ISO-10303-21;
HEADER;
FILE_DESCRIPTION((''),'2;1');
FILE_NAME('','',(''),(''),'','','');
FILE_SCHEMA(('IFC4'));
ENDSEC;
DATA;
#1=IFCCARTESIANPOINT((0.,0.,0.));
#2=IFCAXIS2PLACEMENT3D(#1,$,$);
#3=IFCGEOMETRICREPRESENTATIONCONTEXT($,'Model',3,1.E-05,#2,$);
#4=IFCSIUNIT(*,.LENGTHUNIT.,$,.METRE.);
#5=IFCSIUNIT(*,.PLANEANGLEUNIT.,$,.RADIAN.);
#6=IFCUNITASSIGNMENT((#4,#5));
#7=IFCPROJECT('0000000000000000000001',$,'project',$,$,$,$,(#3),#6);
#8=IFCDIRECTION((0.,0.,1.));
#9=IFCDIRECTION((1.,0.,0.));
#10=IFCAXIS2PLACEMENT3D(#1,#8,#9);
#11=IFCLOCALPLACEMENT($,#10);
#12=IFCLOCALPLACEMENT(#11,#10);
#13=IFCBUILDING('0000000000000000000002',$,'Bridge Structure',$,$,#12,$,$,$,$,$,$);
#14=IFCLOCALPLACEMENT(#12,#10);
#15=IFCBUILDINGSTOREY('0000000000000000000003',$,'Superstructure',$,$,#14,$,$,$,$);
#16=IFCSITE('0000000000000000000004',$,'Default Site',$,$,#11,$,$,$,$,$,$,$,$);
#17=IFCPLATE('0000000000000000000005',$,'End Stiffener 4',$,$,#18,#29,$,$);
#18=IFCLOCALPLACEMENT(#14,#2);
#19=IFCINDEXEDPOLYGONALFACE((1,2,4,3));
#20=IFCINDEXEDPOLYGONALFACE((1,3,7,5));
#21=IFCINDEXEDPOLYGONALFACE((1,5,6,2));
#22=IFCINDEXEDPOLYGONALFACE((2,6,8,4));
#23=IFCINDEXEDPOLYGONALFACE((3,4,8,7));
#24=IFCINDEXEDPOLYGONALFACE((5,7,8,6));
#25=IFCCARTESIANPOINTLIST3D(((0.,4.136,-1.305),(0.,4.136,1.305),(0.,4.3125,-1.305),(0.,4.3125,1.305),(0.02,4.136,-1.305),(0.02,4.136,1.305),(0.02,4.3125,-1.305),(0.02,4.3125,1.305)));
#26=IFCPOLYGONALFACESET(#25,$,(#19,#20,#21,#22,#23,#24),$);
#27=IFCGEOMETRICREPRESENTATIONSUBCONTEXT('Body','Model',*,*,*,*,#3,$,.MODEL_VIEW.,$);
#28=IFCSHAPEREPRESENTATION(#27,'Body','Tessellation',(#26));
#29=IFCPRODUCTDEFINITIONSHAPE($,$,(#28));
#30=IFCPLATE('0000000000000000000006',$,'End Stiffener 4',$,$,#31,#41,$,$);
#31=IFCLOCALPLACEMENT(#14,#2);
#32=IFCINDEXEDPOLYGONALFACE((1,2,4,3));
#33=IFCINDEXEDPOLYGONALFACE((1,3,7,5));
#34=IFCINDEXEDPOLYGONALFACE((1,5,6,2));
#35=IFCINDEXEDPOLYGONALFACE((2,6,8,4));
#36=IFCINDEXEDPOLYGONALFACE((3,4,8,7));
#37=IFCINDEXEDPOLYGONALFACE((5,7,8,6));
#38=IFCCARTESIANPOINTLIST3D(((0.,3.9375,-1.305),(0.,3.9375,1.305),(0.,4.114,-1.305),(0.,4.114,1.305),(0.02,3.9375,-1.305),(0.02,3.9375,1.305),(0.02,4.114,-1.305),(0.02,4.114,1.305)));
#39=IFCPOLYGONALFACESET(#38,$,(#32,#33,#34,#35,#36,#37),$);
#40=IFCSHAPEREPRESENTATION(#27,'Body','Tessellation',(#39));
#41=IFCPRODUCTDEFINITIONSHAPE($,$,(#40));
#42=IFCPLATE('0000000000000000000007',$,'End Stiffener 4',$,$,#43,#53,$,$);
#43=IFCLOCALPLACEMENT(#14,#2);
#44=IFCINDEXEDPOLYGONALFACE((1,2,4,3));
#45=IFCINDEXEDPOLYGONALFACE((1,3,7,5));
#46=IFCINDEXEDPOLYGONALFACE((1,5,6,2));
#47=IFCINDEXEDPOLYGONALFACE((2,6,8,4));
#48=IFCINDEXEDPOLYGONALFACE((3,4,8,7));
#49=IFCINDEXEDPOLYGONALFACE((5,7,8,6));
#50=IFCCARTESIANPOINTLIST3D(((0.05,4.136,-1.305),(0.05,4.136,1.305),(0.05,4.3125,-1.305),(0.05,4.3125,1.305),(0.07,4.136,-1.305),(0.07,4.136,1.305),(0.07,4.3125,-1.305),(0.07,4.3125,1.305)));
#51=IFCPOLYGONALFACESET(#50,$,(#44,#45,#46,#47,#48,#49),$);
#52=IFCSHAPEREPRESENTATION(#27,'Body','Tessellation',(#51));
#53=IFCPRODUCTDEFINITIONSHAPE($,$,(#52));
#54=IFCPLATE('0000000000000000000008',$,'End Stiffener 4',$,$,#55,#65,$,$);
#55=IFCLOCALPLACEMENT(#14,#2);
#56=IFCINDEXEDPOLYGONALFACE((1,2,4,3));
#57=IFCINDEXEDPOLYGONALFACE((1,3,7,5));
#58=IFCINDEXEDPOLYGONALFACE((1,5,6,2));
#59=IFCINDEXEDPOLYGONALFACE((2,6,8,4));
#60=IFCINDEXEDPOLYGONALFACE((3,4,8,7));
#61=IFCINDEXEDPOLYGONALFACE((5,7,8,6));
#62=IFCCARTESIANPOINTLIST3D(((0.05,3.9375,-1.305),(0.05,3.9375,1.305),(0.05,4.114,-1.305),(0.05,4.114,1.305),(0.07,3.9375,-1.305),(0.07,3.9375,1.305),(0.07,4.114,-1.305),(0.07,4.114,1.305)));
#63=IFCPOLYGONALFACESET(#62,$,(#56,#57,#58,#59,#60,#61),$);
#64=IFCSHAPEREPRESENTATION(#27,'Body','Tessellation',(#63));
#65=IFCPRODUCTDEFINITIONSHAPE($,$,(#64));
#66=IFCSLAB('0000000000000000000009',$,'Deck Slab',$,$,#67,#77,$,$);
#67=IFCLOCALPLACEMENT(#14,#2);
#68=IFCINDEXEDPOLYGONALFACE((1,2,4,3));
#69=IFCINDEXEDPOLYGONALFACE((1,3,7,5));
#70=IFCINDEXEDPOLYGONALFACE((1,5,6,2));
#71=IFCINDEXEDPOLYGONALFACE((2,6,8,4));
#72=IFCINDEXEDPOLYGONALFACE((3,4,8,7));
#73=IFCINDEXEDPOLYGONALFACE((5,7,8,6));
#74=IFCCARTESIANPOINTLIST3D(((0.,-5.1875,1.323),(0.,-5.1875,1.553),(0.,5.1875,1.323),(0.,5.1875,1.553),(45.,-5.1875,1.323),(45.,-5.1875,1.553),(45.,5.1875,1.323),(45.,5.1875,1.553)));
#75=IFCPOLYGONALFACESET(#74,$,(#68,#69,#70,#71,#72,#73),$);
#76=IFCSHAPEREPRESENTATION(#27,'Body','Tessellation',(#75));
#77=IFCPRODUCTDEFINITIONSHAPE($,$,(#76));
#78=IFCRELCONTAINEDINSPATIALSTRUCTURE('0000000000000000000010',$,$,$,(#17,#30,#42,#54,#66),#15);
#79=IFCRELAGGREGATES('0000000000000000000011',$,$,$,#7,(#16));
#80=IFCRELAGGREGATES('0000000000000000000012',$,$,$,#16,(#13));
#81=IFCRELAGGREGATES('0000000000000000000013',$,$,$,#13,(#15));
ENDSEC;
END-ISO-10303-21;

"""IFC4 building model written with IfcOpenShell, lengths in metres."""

from ifc_helpers import new_model, si_unit, frame, origin, origin_with_axes, origin_2d_with_axis, place, context, subcontext, project, spatial, polyline, rectangle, outline, extrude, element, save


model = new_model("IFC4")

# Units and contexts
model_context = context("Model", 3, precision=1e-05, world=origin())
body_context = subcontext(model_context, "Body", "Model", "MODEL_VIEW")
ifc_project = project(units=[si_unit("LENGTHUNIT", "METRE"), si_unit("PLANEANGLEUNIT", "RADIAN")], contexts=[model_context])

# Site, building, storey
site_placement = place(None, origin_with_axes())
site = spatial("IfcSite", under=ifc_project, at=site_placement, Name="Default Site")
building_placement = place(site_placement, origin_with_axes())
building = spatial("IfcBuilding", under=site, at=building_placement, Name="Bridge Structure")
storey_placement = place(building_placement, origin_with_axes())
storey = spatial("IfcBuildingStorey", under=building, at=storey_placement, Name="Superstructure")

# Plates
for number, where, z_axis, x_axis, name in (
    (1, (0.01, 4.2243, -1.305), (0.0, 0.0, 1.0), (1.0, 0.0, 0.0), "End Stiffener 4"),
    (2, (0.01, 4.0258, -1.305), (0.0, 0.0, 1.0), (1.0, 0.0, 0.0), "End Stiffener 4"),
    (3, (0.06, 4.2243, -1.305), (0.0, 0.0, 1.0), (1.0, 0.0, 0.0), "End Stiffener 4"),
    (4, (0.06, 4.0258, -1.305), (0.0, 0.0, 1.0), (1.0, 0.0, 0.0), "End Stiffener 4"),
):
    element("IfcPlate", number, at=place(storey_placement, frame(where, z_axis=z_axis, x_axis=x_axis)), inside=storey, Name=name, context=body_context, shape_type="SweptSolid", body=[
        extrude(rectangle(XDim=0.02, YDim=0.1765, at=origin_2d_with_axis()), origin_with_axes(), (0.0, 0.0, 1.0), 2.61),
    ])

# Slab
slab_placement = place(storey_placement, frame((0.0, 0.0, 1.323), z_axis=(0.0, 0.0, 1.0), x_axis=(1.0, 0.0, 0.0)))
element("IfcSlab", 5, at=slab_placement, inside=storey, Name="Deck Slab", context=body_context, shape_type="SweptSolid", body=[
    extrude(outline(polyline([(0.0, -5.1875), (45.0, -5.1875), (45.0, 5.1875), (0.0, 5.1875), (0.0, -5.1875)])), origin_with_axes(), (0.0, 0.0, 1.0), 0.23),
])

save(model, "model.ifc")
